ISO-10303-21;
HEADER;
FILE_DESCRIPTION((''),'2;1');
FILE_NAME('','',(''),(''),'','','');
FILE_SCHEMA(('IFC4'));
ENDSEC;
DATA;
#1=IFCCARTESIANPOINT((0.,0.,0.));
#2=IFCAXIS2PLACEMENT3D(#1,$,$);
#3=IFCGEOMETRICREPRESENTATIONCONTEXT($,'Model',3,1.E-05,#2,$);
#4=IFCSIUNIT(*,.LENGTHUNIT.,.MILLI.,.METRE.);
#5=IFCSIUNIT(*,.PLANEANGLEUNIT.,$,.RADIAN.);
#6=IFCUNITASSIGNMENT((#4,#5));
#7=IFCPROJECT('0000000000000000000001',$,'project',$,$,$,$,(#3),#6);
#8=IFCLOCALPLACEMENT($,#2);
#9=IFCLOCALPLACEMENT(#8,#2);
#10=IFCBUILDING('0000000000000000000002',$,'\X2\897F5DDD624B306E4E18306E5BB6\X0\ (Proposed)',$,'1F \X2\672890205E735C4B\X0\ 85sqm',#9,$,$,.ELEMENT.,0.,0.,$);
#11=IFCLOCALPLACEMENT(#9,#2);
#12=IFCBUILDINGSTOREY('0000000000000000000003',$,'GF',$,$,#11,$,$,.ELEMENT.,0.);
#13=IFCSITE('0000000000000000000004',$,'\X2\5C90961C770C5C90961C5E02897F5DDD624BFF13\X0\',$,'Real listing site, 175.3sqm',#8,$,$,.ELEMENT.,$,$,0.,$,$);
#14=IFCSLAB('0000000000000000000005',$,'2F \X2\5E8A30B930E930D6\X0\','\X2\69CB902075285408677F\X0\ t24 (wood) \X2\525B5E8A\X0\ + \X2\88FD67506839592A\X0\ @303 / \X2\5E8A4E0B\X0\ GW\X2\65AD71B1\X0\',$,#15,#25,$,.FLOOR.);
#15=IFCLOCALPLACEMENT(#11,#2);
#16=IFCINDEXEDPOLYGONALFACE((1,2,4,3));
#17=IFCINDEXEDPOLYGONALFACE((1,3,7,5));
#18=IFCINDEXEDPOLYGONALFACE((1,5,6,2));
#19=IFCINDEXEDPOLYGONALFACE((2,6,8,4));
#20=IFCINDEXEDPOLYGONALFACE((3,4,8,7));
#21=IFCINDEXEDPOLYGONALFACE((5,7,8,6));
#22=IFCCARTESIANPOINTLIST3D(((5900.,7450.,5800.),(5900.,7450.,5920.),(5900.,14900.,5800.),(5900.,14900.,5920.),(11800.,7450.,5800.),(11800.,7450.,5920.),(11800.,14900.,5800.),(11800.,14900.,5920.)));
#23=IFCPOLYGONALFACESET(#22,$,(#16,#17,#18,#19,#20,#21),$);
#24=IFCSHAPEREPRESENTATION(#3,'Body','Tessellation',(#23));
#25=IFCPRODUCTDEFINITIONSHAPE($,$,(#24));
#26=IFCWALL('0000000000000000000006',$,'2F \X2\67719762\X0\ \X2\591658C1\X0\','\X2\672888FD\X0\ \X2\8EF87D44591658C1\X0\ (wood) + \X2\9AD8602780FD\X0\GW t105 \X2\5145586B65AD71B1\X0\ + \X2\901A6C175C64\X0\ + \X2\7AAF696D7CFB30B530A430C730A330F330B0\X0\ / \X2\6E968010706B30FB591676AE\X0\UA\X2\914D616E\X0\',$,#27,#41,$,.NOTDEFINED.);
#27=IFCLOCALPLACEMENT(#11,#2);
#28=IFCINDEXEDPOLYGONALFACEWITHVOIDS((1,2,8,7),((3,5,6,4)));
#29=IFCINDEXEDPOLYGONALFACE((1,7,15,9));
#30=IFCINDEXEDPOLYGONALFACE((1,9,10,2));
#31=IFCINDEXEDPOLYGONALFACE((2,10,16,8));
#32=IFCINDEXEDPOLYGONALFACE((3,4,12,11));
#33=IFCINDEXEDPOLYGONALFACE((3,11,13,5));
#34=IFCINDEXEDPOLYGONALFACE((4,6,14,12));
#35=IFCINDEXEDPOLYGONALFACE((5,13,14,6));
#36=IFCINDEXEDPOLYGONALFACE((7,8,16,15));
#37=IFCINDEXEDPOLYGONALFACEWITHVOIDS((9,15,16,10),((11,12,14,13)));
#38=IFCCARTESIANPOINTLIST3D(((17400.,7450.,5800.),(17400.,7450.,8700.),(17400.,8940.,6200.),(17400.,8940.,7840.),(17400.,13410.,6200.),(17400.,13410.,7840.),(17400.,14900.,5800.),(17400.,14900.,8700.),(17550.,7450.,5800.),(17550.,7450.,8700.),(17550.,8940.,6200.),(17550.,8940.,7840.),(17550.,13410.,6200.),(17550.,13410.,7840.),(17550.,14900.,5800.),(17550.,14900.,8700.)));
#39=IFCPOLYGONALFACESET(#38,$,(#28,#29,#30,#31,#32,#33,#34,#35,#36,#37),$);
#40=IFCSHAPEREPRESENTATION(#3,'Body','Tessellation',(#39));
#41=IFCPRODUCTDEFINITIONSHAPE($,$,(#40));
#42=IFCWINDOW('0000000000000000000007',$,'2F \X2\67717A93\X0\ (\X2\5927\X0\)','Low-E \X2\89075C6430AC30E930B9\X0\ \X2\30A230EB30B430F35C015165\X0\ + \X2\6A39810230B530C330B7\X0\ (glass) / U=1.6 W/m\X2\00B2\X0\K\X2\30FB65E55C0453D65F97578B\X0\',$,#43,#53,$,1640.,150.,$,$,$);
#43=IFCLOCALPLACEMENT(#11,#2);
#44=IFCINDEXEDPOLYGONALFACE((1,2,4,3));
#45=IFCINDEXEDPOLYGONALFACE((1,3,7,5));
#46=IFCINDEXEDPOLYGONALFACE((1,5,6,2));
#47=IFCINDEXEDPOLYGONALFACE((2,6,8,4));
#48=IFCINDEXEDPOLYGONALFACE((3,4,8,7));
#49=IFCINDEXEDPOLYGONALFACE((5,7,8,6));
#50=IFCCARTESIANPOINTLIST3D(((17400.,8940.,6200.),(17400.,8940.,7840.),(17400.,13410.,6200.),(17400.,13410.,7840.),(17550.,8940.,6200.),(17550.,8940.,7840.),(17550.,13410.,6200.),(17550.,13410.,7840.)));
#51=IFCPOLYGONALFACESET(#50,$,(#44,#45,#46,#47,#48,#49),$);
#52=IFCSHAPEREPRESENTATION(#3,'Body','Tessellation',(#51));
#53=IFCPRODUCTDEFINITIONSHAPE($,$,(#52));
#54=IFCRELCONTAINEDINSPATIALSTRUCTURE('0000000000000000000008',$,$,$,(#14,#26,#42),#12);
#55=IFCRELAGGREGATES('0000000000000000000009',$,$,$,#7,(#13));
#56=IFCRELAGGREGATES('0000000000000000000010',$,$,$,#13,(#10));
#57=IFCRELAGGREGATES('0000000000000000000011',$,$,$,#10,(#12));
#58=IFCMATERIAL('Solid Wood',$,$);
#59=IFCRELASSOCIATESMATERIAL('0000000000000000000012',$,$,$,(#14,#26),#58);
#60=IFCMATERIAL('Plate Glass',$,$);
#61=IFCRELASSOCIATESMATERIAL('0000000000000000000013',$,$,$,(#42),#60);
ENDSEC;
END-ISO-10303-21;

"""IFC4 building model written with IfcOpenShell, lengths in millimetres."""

from ifc_helpers import new_model, si_unit, frame, frame_2d, origin, place, context, project, spatial, rectangle, extrude, material, element, fill, save


model = new_model("IFC4")

# Units and contexts
model_context = context("Model", 3, precision=1e-05, world=origin())
ifc_project = project(units=[si_unit("LENGTHUNIT", "METRE", prefix="MILLI"), si_unit("PLANEANGLEUNIT", "RADIAN")], contexts=[model_context])

# Site, building, storey
site_placement = place(None, origin())
site = spatial("IfcSite", under=ifc_project, at=site_placement, Name="岐阜県岐阜市西川手３", ObjectType="Real listing site, 175.3sqm", CompositionType="ELEMENT", RefElevation=0.0)
building_placement = place(site_placement, origin())
building = spatial("IfcBuilding", under=site, at=building_placement, Name="西川手の丘の家 (Proposed)", ObjectType="1F 木造平屋 85sqm", CompositionType="ELEMENT", ElevationOfRefHeight=0.0, ElevationOfTerrain=0.0)
storey_placement = place(building_placement, origin())
storey = spatial("IfcBuildingStorey", under=building, at=storey_placement, Name="GF", CompositionType="ELEMENT", Elevation=0.0)

# Slab
ifc_material_1 = material(Name="Solid Wood")
slab_placement = place(storey_placement, frame((2950.0, 3725.0, 2900.0)))
element("IfcSlab", 1, at=slab_placement, inside=storey, material=ifc_material_1, Name="2F 床スラブ", Description="構造用合板 t24 (wood) 剛床 + 製材根太 @303 / 床下 GW断熱", PredefinedType="FLOOR", context=model_context, shape_type="SweptSolid", body=[
    extrude(rectangle(XDim=5900.0, YDim=7450.0, at=frame_2d((2950.0, 3725.0))), frame((2950.0, 3725.0, 2900.0)), (0.0, 0.0, 1.0), 120.0),
])

# Shared definitions
ifc_material_2 = material(Name="Plate Glass")

# Wall, opening, window
wall_1_placement = place(storey_placement, frame((8700.0, 3725.0, 2900.0)))
wall_1 = element("IfcWall", 2, at=wall_1_placement, inside=storey, material=ifc_material_1, Name="2F 東面 外壁", Description="木製 軸組外壁 (wood) + 高性能GW t105 充填断熱 + 通気層 + 窯業系サイディング / 準耐火・外皮UA配慮", PredefinedType="NOTDEFINED", context=model_context, shape_type="SweptSolid", body=[
    extrude(rectangle(XDim=150.0, YDim=7450.0, at=frame_2d((75.0, 3725.0))), frame((8700.0, 3725.0, 2900.0)), (0.0, 0.0, 1.0), 2900.0),
])
opening_1_placement = place(storey_placement, frame((8700.0, 4470.0, 3100.0)))
opening_1 = element("IfcOpeningElement", 3, at=opening_1_placement, cuts=wall_1, PredefinedType="NOTDEFINED", context=model_context, shape_type="SweptSolid", body=[
    extrude(rectangle(XDim=150.0, YDim=4470.0, at=frame_2d((75.0, 2235.0))), frame((8700.0, 4470.0, 3100.0)), (0.0, 0.0, 1.0), 1640.0),
])
window_1_placement = place(storey_placement, frame((8700.0, 4470.0, 3100.0)))
window_1 = element("IfcWindow", 4, at=window_1_placement, inside=storey, material=ifc_material_2, Name="2F 東窓 (大)", Description="Low-E 複層ガラス アルゴン封入 + 樹脂サッシ (glass) / U=1.6 W/m²K・日射取得型", OverallHeight=1640.0, OverallWidth=150.0, context=model_context, shape_type="SweptSolid", body=[
    extrude(rectangle(XDim=150.0, YDim=4470.0, at=frame_2d((75.0, 2235.0))), frame((8700.0, 4470.0, 3100.0)), (0.0, 0.0, 1.0), 1640.0),
])
fill(opening_1, window_1)

save(model, "model.ifc")
